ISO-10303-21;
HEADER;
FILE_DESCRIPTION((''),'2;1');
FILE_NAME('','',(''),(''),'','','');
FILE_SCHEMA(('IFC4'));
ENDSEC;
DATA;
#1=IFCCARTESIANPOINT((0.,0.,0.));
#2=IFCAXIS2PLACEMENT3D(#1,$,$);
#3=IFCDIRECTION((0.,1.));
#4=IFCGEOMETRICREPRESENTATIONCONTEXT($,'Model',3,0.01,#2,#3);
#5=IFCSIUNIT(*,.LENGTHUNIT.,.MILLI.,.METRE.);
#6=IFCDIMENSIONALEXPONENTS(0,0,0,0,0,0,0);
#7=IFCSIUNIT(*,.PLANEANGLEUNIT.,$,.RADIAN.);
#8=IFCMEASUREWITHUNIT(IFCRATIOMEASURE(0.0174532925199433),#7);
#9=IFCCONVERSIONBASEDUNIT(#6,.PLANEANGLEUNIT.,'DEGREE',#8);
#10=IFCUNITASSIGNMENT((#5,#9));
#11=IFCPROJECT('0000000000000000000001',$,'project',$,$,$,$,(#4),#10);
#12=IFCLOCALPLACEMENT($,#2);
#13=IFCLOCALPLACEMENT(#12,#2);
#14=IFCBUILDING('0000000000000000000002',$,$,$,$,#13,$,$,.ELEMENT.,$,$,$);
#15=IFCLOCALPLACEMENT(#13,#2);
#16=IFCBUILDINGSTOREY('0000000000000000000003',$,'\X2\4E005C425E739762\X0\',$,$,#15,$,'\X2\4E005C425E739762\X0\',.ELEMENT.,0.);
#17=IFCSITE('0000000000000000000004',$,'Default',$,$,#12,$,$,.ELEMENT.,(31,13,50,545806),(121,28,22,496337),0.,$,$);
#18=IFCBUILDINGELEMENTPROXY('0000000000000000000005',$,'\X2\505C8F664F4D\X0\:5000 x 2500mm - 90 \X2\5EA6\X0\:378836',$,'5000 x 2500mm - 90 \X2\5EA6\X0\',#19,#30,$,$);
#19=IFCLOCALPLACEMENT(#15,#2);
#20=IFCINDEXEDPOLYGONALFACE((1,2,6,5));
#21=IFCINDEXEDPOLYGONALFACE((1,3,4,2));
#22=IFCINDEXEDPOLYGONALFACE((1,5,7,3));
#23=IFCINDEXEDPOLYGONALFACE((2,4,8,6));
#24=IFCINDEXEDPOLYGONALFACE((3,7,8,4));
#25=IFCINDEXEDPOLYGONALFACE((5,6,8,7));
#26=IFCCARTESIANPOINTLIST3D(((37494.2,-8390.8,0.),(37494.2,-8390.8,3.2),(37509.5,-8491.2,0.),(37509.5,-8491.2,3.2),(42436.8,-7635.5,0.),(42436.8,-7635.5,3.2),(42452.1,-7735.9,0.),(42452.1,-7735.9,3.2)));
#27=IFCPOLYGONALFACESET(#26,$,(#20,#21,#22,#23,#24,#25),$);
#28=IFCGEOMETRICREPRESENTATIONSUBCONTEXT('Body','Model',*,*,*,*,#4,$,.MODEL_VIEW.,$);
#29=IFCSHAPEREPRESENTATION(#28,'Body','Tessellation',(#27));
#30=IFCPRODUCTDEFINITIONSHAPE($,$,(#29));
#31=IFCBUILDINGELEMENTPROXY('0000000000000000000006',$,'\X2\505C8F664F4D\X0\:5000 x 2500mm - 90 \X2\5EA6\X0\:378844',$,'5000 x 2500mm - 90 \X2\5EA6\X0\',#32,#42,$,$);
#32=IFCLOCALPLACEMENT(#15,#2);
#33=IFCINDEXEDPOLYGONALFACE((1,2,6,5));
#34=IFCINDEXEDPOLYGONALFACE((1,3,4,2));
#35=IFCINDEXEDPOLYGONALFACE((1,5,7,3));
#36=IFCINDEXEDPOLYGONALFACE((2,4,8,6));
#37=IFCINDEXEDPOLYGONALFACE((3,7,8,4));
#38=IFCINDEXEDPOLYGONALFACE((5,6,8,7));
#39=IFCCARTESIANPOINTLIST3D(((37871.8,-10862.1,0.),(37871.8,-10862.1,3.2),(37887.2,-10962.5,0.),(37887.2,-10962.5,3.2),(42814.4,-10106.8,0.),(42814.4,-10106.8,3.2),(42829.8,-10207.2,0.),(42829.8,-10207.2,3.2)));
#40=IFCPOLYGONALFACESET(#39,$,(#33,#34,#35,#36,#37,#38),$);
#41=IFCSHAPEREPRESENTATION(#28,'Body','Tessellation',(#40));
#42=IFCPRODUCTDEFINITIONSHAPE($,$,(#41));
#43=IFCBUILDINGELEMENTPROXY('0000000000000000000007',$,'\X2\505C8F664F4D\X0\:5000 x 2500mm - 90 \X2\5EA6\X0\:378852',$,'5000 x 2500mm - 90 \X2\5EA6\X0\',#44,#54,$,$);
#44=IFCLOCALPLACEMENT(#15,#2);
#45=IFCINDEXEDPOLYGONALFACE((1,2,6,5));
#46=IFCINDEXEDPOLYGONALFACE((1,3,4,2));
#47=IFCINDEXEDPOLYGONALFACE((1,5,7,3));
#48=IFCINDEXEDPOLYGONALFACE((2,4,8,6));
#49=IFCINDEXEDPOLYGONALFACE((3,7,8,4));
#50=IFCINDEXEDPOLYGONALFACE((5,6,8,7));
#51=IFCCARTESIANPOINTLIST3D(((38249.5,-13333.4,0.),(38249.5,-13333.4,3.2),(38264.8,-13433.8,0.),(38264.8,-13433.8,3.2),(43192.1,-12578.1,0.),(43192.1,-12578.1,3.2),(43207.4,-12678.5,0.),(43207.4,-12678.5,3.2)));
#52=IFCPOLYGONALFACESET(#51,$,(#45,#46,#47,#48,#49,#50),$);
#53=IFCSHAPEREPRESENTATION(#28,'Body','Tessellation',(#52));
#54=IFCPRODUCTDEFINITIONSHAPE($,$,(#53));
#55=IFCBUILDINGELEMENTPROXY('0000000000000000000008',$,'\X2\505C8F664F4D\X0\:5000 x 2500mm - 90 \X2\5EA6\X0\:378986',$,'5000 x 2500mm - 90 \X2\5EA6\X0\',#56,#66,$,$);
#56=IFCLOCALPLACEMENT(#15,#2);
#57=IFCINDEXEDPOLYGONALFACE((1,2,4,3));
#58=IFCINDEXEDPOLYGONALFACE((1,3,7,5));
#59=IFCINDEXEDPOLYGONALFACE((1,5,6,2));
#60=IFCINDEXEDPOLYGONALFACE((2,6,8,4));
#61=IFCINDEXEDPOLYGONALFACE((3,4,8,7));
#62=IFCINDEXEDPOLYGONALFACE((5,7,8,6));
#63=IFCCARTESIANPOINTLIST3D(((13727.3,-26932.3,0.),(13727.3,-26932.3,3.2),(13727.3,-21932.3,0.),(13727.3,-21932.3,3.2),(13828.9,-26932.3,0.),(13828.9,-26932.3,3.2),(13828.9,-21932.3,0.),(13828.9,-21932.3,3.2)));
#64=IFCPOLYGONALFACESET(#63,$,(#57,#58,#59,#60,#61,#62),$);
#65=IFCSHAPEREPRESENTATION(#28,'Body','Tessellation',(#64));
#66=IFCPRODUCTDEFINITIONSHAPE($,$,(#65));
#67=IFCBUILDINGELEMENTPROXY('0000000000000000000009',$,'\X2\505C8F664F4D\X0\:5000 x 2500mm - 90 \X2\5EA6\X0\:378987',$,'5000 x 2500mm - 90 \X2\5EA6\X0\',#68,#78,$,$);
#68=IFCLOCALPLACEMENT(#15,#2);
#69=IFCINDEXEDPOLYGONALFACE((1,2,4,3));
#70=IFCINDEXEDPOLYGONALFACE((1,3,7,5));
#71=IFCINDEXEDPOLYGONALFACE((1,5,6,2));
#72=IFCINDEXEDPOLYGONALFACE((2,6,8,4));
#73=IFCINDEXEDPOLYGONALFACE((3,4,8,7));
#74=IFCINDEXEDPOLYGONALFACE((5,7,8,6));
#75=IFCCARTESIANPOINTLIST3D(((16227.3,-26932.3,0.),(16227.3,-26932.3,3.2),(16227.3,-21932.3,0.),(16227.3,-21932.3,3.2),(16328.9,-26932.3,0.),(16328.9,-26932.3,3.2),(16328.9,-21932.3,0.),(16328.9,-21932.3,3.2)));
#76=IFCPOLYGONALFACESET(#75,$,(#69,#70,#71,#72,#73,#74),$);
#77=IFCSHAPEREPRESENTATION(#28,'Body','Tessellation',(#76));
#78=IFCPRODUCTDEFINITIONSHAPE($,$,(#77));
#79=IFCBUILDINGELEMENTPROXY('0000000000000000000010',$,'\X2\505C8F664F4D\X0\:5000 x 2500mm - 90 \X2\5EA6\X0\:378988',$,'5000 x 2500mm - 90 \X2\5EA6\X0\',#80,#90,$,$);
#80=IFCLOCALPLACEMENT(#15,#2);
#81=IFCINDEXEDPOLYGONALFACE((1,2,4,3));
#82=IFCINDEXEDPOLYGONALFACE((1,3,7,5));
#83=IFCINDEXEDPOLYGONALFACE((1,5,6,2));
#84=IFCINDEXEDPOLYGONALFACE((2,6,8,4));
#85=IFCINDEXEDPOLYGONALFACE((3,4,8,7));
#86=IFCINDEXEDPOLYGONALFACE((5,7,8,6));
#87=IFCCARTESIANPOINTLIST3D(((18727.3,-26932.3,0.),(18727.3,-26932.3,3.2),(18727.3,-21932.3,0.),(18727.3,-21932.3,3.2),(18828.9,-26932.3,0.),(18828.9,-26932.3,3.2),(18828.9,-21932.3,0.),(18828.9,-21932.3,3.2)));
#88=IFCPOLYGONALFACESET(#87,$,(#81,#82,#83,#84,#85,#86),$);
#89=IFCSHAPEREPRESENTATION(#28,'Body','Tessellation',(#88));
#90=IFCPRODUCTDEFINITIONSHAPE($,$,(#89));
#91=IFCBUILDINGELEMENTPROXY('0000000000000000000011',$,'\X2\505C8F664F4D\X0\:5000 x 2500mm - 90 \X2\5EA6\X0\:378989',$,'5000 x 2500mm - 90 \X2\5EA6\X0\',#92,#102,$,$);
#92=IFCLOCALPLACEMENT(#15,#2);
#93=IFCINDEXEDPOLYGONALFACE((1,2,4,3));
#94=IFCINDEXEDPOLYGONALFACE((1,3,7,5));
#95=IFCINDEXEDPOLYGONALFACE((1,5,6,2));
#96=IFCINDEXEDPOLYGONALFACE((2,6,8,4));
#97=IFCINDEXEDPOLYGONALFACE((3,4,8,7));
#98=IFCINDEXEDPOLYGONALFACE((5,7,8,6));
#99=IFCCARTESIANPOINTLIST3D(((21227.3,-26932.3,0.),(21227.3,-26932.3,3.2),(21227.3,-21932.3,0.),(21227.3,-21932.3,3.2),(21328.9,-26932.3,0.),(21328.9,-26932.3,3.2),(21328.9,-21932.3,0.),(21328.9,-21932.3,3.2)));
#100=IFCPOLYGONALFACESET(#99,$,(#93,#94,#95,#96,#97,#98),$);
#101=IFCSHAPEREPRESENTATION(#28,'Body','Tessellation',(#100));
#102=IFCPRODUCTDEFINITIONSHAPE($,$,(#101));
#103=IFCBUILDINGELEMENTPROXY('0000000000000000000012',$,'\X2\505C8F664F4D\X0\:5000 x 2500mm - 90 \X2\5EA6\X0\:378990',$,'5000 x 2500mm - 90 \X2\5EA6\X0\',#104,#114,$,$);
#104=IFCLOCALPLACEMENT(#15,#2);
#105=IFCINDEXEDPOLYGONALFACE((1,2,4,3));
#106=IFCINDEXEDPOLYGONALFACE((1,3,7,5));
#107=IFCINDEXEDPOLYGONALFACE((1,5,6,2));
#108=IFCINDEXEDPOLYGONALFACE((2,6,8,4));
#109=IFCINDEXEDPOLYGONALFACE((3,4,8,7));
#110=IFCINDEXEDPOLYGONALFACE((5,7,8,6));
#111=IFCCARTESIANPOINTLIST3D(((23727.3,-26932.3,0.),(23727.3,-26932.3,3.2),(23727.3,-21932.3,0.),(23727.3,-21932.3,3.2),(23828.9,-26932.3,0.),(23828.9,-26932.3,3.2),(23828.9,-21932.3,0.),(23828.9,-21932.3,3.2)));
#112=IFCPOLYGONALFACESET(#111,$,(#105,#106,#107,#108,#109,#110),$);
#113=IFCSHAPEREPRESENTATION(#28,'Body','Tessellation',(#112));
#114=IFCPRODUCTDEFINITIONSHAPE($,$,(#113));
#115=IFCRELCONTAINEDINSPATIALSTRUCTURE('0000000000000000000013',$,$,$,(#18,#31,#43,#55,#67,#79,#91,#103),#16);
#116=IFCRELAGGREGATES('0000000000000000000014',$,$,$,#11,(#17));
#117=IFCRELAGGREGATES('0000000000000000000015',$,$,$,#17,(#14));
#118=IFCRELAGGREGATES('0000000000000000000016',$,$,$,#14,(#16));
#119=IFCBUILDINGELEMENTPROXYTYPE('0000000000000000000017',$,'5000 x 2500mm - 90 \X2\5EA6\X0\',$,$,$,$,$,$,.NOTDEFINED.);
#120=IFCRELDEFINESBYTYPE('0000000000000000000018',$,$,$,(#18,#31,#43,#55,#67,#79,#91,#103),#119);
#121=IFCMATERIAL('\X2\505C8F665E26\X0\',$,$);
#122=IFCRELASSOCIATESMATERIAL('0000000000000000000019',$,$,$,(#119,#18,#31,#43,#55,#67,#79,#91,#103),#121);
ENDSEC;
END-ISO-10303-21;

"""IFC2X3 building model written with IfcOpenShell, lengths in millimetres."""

from ifc_helpers import new_model, entity, si_unit, converted_unit, direction, frame, origin, origin_2d_with_axis, place, context, subcontext, project, spatial, rectangle, extrude, source, transform, mapped, material, type_object, type_shapes, element, save


model = new_model("IFC2X3")

# Units and contexts
model_context = context("Model", 3, precision=0.01, world=origin(), true_north=direction((0.0, 1.0)))
body_context = subcontext(model_context, "Body", "Model", "MODEL_VIEW")
ifc_project = project(units=[si_unit("LENGTHUNIT", "METRE", prefix="MILLI"), converted_unit("PLANEANGLEUNIT", "DEGREE", entity("IfcRatioMeasure", 0.0174532925199433), si_unit("PLANEANGLEUNIT", "RADIAN"), dimensions=[0, 0, 0, 0, 0, 0, 0])], contexts=[model_context])

# Site, building, storey
site_placement = place(None, origin())
site = spatial("IfcSite", under=ifc_project, at=site_placement, Name="Default", CompositionType="ELEMENT", RefLatitude=(31, 13, 50, 545806), RefLongitude=(121, 28, 22, 496337), RefElevation=0.0)
building_placement = place(site_placement, origin())
building = spatial("IfcBuilding", under=site, at=building_placement, CompositionType="ELEMENT")
storey_placement = place(building_placement, origin())
storey = spatial("IfcBuildingStorey", under=building, at=storey_placement, Name="一层平面", LongName="一层平面", CompositionType="ELEMENT", Elevation=0.0)

# Building element proxies
ifc_material_1 = material(Name="停车带")
building_element_proxy_type = type_object("IfcBuildingElementProxyType", Name="5000 x 2500mm - 90 度", PredefinedType="NOTDEFINED", material=ifc_material_1)
shared_shape = source(origin(), body_context, "Body", "SweptSolid", [
    extrude(rectangle(XDim=101.6, YDim=5000.0, at=origin_2d_with_axis()), frame((0.0, 2500.0, 0.0)), (0.0, 0.0, 1.0), 3.2),
])
type_shapes(building_element_proxy_type, [shared_shape])
for number, where, z_axis, x_axis, name in (
    (1, (37501.8, -8441.0, 0.0), (0.0, 0.0, 1.0), (0.151059, -0.988525, 0.0), "停车位:5000 x 2500mm - 90 度:378836"),
    (2, (37879.5, -10912.3, 0.0), (0.0, 0.0, 1.0), (0.151059, -0.988525, 0.0), "停车位:5000 x 2500mm - 90 度:378844"),
    (3, (38257.1, -13383.6, 0.0), (0.0, 0.0, 1.0), (0.151059, -0.988525, 0.0), "停车位:5000 x 2500mm - 90 度:378852"),
    (4, (13778.1, -21932.3, 0.0), (0.0, 0.0, 1.0), (-1.0, 0.0, 0.0), "停车位:5000 x 2500mm - 90 度:378986"),
    (5, (16278.1, -21932.3, 0.0), (0.0, 0.0, 1.0), (-1.0, 0.0, 0.0), "停车位:5000 x 2500mm - 90 度:378987"),
    (6, (18778.1, -21932.3, 0.0), (0.0, 0.0, 1.0), (-1.0, 0.0, 0.0), "停车位:5000 x 2500mm - 90 度:378988"),
    (7, (21278.1, -21932.3, 0.0), (0.0, 0.0, 1.0), (-1.0, 0.0, 0.0), "停车位:5000 x 2500mm - 90 度:378989"),
    (8, (23778.1, -21932.3, 0.0), (0.0, 0.0, 1.0), (-1.0, 0.0, 0.0), "停车位:5000 x 2500mm - 90 度:378990"),
):
    element("IfcBuildingElementProxy", number, at=place(storey_placement, frame(where, z_axis=z_axis, x_axis=x_axis)), inside=storey, type_object=building_element_proxy_type, material=ifc_material_1, Name=name, ObjectType="5000 x 2500mm - 90 度", context=body_context, shape_type="MappedRepresentation", body=[
        mapped(shared_shape, transform((0.0, 0.0, 0.0), scale=1.0)),
    ])

save(model, "model.ifc")
